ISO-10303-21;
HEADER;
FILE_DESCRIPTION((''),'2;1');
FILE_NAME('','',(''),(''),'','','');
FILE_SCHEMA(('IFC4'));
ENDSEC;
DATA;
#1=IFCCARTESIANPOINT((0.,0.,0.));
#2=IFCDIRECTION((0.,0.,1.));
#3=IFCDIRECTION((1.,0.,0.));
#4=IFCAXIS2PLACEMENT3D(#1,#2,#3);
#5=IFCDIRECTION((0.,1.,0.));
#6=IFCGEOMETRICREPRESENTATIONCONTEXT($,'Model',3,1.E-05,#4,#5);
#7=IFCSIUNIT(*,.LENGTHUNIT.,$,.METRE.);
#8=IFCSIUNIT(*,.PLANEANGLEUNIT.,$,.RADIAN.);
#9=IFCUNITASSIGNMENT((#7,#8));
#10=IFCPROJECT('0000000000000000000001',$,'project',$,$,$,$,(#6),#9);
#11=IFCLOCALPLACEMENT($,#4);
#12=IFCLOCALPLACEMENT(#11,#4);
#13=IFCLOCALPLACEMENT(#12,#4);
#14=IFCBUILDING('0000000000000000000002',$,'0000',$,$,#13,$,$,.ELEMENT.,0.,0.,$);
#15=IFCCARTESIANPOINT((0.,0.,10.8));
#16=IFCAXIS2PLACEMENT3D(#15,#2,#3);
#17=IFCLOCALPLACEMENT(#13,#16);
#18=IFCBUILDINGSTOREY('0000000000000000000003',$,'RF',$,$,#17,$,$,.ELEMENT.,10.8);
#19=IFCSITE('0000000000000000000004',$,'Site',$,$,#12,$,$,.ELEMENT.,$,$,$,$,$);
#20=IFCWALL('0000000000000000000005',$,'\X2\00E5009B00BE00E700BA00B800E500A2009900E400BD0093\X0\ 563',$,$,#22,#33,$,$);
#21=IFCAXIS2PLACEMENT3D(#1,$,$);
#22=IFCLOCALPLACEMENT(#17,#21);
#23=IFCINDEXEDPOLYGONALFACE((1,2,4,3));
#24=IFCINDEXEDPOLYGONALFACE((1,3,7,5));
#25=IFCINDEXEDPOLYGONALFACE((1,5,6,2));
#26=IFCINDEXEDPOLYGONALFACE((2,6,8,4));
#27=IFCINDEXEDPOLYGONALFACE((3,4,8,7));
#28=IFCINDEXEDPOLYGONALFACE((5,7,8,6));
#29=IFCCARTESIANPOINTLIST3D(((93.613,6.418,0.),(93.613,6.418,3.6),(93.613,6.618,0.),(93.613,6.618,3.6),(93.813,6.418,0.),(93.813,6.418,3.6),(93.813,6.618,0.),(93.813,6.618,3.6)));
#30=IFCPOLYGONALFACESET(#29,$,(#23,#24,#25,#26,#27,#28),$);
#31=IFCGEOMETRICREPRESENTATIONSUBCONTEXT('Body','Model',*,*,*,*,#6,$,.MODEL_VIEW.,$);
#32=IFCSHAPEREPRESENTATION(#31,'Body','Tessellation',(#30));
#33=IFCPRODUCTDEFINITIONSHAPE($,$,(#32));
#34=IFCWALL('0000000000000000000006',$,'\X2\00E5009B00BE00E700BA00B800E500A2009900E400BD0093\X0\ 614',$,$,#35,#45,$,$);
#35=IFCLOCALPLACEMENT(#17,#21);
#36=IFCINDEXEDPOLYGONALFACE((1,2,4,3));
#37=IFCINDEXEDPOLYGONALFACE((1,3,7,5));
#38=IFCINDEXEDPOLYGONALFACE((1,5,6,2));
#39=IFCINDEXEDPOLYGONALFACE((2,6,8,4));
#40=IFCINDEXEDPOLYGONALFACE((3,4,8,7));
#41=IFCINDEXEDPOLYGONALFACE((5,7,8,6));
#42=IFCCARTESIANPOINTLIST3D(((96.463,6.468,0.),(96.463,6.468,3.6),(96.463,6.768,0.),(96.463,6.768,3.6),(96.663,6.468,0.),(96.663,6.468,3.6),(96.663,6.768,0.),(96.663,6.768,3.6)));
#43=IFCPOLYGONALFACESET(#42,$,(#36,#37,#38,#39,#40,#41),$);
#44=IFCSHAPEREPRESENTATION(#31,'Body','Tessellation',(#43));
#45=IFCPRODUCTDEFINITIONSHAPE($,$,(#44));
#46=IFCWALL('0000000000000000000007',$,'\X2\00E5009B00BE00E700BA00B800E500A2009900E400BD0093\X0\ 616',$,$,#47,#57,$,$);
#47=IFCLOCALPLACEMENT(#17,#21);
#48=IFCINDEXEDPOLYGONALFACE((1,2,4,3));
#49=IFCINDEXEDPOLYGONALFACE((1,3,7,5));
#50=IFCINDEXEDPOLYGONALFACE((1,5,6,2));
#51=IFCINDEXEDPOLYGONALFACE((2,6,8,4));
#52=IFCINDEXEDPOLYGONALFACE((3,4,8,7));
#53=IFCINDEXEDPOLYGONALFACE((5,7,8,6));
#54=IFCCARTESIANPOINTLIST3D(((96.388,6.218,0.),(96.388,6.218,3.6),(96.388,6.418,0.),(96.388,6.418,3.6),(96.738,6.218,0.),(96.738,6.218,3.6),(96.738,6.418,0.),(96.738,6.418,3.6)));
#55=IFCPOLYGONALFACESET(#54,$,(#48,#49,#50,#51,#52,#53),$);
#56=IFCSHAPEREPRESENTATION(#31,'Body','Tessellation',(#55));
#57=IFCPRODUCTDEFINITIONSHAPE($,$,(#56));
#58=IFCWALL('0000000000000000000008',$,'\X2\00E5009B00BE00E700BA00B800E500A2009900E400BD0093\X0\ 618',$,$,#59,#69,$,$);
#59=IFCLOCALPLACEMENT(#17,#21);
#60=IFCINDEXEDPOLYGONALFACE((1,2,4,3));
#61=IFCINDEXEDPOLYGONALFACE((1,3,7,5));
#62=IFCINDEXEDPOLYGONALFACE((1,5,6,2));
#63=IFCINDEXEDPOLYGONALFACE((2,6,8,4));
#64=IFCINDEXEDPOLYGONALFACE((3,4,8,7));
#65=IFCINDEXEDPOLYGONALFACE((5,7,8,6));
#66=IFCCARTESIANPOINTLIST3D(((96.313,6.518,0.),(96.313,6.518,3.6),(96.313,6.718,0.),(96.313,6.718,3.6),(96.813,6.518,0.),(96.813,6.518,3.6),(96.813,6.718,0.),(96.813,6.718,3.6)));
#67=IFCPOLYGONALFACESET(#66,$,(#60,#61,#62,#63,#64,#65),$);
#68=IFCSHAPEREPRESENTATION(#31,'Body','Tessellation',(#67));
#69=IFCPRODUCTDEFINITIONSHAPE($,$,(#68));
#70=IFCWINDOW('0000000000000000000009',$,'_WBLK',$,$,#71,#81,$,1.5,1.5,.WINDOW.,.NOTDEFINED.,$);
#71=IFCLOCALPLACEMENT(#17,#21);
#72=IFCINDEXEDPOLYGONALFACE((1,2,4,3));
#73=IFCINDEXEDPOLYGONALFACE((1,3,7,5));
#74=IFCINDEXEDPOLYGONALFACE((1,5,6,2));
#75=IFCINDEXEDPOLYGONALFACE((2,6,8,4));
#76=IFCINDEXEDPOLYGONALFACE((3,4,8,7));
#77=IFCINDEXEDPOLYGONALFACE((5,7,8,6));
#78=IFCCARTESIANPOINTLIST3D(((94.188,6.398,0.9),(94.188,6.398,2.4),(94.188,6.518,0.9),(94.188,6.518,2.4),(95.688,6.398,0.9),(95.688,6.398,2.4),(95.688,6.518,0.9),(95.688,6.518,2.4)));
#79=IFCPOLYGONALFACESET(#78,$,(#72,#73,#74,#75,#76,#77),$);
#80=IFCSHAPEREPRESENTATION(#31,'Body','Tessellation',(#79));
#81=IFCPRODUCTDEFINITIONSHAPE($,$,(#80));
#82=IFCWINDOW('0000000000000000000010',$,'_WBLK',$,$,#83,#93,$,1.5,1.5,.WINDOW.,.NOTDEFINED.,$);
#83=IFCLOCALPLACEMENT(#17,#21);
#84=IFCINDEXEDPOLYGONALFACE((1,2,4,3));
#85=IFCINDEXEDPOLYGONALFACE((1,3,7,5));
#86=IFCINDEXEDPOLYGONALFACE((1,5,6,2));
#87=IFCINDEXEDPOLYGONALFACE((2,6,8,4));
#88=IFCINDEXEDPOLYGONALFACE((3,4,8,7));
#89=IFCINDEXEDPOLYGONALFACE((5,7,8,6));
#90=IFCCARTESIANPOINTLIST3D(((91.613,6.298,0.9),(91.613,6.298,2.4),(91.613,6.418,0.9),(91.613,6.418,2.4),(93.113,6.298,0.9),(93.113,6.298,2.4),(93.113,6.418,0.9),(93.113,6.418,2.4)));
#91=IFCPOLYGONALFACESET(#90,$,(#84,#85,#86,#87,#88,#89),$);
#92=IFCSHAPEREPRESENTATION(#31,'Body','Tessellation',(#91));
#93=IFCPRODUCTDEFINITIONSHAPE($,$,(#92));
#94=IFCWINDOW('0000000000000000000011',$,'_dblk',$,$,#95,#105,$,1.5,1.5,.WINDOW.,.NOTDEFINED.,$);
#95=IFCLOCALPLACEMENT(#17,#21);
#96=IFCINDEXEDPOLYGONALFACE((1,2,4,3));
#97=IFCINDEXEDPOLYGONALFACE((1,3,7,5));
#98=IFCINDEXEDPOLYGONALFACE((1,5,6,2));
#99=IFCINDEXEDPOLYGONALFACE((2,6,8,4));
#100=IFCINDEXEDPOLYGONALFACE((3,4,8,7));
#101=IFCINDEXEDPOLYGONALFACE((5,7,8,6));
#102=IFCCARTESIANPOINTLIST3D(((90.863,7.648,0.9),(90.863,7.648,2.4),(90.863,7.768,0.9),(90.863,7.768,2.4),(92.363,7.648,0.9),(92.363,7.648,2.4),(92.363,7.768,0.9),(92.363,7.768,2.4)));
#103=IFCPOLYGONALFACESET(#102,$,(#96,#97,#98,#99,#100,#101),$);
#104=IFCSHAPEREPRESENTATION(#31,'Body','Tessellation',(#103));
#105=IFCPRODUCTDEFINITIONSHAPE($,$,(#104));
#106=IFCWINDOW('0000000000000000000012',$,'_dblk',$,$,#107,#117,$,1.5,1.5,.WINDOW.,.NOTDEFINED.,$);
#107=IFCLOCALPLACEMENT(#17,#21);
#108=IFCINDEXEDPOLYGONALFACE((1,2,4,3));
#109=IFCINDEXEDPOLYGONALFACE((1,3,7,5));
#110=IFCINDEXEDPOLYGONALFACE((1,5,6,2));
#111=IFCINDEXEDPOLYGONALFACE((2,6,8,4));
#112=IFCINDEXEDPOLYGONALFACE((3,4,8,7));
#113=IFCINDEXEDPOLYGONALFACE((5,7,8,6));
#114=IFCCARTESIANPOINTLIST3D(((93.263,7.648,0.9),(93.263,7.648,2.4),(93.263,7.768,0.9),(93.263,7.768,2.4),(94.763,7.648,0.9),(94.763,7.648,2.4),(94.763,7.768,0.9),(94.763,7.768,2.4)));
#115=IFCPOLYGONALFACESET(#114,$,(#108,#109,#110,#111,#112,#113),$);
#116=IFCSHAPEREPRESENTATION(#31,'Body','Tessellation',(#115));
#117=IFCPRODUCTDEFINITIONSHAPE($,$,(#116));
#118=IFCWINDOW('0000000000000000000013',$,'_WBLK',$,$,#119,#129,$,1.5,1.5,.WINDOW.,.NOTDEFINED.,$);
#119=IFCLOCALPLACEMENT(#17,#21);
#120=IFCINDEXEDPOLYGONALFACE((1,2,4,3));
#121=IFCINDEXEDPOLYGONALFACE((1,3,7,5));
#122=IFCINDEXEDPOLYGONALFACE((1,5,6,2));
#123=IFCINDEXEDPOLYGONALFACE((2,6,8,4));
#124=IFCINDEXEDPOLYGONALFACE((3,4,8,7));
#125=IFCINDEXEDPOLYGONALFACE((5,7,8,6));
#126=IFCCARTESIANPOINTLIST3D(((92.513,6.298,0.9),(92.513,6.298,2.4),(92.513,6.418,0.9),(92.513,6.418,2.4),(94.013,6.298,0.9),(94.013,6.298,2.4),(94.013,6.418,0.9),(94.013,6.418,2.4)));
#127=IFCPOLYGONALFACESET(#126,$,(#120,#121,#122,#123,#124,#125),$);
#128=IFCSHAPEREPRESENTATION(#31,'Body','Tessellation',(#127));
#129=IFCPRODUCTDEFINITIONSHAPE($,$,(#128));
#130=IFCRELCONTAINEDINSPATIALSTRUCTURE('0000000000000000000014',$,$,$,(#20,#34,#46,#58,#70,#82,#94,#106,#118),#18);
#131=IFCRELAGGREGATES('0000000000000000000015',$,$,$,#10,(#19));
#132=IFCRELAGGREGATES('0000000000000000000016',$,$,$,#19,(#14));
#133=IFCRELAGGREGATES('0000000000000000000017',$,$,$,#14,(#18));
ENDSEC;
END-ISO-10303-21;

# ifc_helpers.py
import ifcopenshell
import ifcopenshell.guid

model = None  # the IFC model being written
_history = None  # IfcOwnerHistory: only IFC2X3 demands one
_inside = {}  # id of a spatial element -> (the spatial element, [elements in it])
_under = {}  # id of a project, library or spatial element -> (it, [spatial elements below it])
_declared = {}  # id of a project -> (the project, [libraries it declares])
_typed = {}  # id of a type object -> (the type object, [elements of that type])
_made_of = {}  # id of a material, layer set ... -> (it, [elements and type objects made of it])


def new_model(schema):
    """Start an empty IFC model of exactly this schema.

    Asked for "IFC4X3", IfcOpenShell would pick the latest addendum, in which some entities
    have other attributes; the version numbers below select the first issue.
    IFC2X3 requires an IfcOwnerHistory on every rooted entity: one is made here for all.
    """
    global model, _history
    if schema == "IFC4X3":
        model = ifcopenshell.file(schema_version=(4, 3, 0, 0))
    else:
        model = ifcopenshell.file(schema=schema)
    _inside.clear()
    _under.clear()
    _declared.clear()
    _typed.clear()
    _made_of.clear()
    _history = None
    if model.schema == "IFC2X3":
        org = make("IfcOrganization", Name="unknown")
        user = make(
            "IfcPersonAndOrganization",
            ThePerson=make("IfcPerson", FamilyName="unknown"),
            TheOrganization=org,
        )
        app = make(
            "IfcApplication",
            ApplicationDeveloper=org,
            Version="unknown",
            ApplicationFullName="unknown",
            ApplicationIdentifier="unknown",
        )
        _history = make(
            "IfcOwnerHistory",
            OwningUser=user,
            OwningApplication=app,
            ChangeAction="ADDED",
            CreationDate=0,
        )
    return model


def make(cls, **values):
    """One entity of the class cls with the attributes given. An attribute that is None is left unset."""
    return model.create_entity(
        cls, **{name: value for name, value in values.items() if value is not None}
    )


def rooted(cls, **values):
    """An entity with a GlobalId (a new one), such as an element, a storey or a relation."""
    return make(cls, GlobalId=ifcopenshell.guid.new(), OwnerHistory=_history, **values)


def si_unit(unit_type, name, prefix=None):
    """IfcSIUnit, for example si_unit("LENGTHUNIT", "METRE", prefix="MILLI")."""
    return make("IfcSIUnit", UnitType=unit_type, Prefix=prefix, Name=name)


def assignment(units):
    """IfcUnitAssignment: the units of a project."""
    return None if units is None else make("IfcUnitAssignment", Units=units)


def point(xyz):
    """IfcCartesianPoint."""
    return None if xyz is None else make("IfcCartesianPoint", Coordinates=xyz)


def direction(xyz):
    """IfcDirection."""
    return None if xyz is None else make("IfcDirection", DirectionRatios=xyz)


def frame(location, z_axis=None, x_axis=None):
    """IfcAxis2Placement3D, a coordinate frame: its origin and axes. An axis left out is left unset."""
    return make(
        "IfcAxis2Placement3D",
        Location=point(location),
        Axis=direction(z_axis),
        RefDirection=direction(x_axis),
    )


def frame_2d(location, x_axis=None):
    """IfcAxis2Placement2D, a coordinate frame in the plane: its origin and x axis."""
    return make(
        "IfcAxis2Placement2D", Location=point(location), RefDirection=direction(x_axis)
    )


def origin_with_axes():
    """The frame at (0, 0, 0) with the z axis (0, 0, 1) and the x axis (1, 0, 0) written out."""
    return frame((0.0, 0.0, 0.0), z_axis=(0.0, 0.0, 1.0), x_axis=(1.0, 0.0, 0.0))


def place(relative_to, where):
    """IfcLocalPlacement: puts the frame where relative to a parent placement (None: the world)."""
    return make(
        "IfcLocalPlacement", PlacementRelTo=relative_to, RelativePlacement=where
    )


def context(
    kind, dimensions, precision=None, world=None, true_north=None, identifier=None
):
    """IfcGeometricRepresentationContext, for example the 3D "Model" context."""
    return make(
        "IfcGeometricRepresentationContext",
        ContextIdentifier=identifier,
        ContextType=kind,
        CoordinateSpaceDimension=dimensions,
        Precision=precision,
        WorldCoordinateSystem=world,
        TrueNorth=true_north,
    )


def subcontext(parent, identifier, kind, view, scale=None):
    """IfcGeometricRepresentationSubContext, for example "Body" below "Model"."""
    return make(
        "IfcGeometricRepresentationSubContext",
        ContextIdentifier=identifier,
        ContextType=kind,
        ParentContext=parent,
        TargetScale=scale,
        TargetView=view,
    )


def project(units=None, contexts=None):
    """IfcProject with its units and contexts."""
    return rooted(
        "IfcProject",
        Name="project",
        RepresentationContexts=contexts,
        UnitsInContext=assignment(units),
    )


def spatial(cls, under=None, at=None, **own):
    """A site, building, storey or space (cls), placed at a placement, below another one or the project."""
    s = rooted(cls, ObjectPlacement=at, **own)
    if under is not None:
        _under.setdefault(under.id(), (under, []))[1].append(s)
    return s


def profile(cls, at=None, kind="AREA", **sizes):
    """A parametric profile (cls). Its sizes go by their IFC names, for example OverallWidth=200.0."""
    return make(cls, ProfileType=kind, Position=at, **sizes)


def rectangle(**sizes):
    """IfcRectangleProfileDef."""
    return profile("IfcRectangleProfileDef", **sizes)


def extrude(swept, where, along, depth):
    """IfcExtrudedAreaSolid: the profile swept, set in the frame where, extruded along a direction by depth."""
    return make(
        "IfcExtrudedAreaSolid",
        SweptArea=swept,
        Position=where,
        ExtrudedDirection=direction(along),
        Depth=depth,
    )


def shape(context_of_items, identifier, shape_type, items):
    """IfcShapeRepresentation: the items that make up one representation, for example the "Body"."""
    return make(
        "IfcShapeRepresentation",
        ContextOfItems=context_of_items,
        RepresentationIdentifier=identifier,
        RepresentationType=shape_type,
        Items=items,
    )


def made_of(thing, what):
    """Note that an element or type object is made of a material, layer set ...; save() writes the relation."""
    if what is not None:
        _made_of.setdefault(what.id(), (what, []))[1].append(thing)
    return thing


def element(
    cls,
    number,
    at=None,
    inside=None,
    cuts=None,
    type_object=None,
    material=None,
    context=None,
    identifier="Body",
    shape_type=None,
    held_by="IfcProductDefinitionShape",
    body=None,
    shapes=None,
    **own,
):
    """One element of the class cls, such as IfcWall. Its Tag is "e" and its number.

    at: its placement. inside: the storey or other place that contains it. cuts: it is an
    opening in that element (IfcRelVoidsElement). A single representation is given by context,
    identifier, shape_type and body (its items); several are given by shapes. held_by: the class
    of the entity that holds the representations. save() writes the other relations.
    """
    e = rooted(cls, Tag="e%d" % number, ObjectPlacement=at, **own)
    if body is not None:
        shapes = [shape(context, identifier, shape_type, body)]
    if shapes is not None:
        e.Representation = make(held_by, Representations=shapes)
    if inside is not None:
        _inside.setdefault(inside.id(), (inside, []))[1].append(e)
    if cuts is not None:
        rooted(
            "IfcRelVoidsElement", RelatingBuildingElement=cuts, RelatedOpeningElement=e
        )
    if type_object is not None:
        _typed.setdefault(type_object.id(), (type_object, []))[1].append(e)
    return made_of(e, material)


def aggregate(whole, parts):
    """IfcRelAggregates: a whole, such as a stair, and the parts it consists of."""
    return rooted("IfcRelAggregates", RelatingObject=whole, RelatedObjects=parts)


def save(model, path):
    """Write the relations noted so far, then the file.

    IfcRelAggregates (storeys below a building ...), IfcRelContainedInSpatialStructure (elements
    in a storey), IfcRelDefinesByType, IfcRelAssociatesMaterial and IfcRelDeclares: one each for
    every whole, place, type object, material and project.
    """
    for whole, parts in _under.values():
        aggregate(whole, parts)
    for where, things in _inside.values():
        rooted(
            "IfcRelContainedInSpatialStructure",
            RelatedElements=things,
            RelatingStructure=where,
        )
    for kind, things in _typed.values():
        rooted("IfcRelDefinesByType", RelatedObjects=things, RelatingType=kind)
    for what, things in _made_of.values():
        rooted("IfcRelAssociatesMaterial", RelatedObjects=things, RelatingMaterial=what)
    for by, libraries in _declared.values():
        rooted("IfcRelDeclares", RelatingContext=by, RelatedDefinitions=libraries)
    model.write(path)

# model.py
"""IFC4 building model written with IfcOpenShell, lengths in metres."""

from ifc_helpers import new_model, si_unit, direction, frame, frame_2d, origin_with_axes, place, context, subcontext, project, spatial, rectangle, extrude, element, save


model = new_model("IFC4")

# Units and contexts
model_context = context("Model", 3, precision=1e-05, world=origin_with_axes(), true_north=direction((0.0, 1.0, 0.0)))
body_context = subcontext(model_context, "Body", "Model", "MODEL_VIEW")
ifc_project = project(units=[si_unit("LENGTHUNIT", "METRE"), si_unit("PLANEANGLEUNIT", "RADIAN")], contexts=[model_context])

# Site, building, storey
placement = place(None, origin_with_axes())
site_placement = place(placement, origin_with_axes())
site = spatial("IfcSite", under=ifc_project, at=site_placement, Name="Site", CompositionType="ELEMENT")
building_placement = place(site_placement, origin_with_axes())
building = spatial("IfcBuilding", under=site, at=building_placement, Name="0000", CompositionType="ELEMENT", ElevationOfRefHeight=0.0, ElevationOfTerrain=0.0)
storey_placement = place(building_placement, frame((0.0, 0.0, 10.8), z_axis=(0.0, 0.0, 1.0), x_axis=(1.0, 0.0, 0.0)))
storey = spatial("IfcBuildingStorey", under=building, at=storey_placement, Name="RF", CompositionType="ELEMENT", Elevation=10.8)

# Walls
for number, where, z_axis, x_axis, name in (
    (1, (93.713, 6.518, 0.0), (0.0, 0.0, 1.0), (0.0, -1.0, 0.0), "å\u009b¾çº¸å¢\u0099ä½\u0093 563"),
):
    element("IfcWall", number, at=place(storey_placement, frame(where, z_axis=z_axis, x_axis=x_axis)), inside=storey, Name=name, context=body_context, shape_type="SweptSolid", body=[
        extrude(rectangle(XDim=0.2, YDim=0.2, at=frame_2d((0.0, 0.0), x_axis=(1.0, 0.0, 0.0))), frame((0.0, 0.0, 0.0), z_axis=(0.0, 0.0, 1.0)), (0.0, 0.0, 1.0), 3.6),
    ])
wall_1_placement = place(storey_placement, frame((96.563, 6.618, 0.0), z_axis=(0.0, 0.0, 1.0), x_axis=(0.0, -1.0, 0.0)))
element("IfcWall", 2, at=wall_1_placement, inside=storey, Name="å\u009b¾çº¸å¢\u0099ä½\u0093 614", context=body_context, shape_type="SweptSolid", body=[
    extrude(rectangle(XDim=0.3, YDim=0.2, at=frame_2d((0.0, 0.0), x_axis=(1.0, 0.0, 0.0))), frame((0.0, 0.0, 0.0), z_axis=(0.0, 0.0, 1.0)), (0.0, 0.0, 1.0), 3.6),
])
wall_2_placement = place(storey_placement, frame((96.563, 6.318, 0.0), z_axis=(0.0, 0.0, 1.0), x_axis=(1.0, 0.0, 0.0)))
element("IfcWall", 3, at=wall_2_placement, inside=storey, Name="å\u009b¾çº¸å¢\u0099ä½\u0093 616", context=body_context, shape_type="SweptSolid", body=[
    extrude(rectangle(XDim=0.35, YDim=0.2, at=frame_2d((0.0, 0.0), x_axis=(1.0, 0.0, 0.0))), frame((0.0, 0.0, 0.0), z_axis=(0.0, 0.0, 1.0)), (0.0, 0.0, 1.0), 3.6),
])
for number, where, z_axis, x_axis, name in (
    (4, (96.563, 6.618, 0.0), (0.0, 0.0, 1.0), (1.0, 0.0, 0.0), "å\u009b¾çº¸å¢\u0099ä½\u0093 618"),
):
    element("IfcWall", number, at=place(storey_placement, frame(where, z_axis=z_axis, x_axis=x_axis)), inside=storey, Name=name, context=body_context, shape_type="SweptSolid", body=[
        extrude(rectangle(XDim=0.5, YDim=0.2, at=frame_2d((0.0, 0.0), x_axis=(1.0, 0.0, 0.0))), frame((0.0, 0.0, 0.0), z_axis=(0.0, 0.0, 1.0)), (0.0, 0.0, 1.0), 3.6),
    ])

# Windows
for number, where, z_axis, x_axis, name in (
    (5, (94.938, 6.458, 0.9), (0.0, 0.0, 1.0), (1.0, 0.0, 0.0), "_WBLK"),
    (6, (92.363, 6.358, 0.9), (0.0, 0.0, 1.0), (1.0, 0.0, 0.0), "_WBLK"),
    (7, (91.613, 7.708, 0.9), (0.0, 0.0, 1.0), (1.0, 0.0, 0.0), "_dblk"),
    (8, (94.013, 7.708, 0.9), (0.0, 0.0, 1.0), (1.0, 0.0, 0.0), "_dblk"),
    (9, (93.263, 6.358, 0.9), (0.0, 0.0, 1.0), (1.0, 0.0, 0.0), "_WBLK"),
):
    element("IfcWindow", number, at=place(storey_placement, frame(where, z_axis=z_axis, x_axis=x_axis)), inside=storey, Name=name, OverallHeight=1.5, OverallWidth=1.5, PartitioningType="NOTDEFINED", PredefinedType="WINDOW", context=body_context, shape_type="SweptSolid", body=[
        extrude(rectangle(XDim=1.5, YDim=0.12, at=frame_2d((0.0, 0.0), x_axis=(1.0, 0.0, 0.0))), frame((0.0, 0.0, 0.0), z_axis=(0.0, 0.0, 1.0)), (0.0, 0.0, 1.0), 1.5),
    ])

save(model, "model.ifc")
